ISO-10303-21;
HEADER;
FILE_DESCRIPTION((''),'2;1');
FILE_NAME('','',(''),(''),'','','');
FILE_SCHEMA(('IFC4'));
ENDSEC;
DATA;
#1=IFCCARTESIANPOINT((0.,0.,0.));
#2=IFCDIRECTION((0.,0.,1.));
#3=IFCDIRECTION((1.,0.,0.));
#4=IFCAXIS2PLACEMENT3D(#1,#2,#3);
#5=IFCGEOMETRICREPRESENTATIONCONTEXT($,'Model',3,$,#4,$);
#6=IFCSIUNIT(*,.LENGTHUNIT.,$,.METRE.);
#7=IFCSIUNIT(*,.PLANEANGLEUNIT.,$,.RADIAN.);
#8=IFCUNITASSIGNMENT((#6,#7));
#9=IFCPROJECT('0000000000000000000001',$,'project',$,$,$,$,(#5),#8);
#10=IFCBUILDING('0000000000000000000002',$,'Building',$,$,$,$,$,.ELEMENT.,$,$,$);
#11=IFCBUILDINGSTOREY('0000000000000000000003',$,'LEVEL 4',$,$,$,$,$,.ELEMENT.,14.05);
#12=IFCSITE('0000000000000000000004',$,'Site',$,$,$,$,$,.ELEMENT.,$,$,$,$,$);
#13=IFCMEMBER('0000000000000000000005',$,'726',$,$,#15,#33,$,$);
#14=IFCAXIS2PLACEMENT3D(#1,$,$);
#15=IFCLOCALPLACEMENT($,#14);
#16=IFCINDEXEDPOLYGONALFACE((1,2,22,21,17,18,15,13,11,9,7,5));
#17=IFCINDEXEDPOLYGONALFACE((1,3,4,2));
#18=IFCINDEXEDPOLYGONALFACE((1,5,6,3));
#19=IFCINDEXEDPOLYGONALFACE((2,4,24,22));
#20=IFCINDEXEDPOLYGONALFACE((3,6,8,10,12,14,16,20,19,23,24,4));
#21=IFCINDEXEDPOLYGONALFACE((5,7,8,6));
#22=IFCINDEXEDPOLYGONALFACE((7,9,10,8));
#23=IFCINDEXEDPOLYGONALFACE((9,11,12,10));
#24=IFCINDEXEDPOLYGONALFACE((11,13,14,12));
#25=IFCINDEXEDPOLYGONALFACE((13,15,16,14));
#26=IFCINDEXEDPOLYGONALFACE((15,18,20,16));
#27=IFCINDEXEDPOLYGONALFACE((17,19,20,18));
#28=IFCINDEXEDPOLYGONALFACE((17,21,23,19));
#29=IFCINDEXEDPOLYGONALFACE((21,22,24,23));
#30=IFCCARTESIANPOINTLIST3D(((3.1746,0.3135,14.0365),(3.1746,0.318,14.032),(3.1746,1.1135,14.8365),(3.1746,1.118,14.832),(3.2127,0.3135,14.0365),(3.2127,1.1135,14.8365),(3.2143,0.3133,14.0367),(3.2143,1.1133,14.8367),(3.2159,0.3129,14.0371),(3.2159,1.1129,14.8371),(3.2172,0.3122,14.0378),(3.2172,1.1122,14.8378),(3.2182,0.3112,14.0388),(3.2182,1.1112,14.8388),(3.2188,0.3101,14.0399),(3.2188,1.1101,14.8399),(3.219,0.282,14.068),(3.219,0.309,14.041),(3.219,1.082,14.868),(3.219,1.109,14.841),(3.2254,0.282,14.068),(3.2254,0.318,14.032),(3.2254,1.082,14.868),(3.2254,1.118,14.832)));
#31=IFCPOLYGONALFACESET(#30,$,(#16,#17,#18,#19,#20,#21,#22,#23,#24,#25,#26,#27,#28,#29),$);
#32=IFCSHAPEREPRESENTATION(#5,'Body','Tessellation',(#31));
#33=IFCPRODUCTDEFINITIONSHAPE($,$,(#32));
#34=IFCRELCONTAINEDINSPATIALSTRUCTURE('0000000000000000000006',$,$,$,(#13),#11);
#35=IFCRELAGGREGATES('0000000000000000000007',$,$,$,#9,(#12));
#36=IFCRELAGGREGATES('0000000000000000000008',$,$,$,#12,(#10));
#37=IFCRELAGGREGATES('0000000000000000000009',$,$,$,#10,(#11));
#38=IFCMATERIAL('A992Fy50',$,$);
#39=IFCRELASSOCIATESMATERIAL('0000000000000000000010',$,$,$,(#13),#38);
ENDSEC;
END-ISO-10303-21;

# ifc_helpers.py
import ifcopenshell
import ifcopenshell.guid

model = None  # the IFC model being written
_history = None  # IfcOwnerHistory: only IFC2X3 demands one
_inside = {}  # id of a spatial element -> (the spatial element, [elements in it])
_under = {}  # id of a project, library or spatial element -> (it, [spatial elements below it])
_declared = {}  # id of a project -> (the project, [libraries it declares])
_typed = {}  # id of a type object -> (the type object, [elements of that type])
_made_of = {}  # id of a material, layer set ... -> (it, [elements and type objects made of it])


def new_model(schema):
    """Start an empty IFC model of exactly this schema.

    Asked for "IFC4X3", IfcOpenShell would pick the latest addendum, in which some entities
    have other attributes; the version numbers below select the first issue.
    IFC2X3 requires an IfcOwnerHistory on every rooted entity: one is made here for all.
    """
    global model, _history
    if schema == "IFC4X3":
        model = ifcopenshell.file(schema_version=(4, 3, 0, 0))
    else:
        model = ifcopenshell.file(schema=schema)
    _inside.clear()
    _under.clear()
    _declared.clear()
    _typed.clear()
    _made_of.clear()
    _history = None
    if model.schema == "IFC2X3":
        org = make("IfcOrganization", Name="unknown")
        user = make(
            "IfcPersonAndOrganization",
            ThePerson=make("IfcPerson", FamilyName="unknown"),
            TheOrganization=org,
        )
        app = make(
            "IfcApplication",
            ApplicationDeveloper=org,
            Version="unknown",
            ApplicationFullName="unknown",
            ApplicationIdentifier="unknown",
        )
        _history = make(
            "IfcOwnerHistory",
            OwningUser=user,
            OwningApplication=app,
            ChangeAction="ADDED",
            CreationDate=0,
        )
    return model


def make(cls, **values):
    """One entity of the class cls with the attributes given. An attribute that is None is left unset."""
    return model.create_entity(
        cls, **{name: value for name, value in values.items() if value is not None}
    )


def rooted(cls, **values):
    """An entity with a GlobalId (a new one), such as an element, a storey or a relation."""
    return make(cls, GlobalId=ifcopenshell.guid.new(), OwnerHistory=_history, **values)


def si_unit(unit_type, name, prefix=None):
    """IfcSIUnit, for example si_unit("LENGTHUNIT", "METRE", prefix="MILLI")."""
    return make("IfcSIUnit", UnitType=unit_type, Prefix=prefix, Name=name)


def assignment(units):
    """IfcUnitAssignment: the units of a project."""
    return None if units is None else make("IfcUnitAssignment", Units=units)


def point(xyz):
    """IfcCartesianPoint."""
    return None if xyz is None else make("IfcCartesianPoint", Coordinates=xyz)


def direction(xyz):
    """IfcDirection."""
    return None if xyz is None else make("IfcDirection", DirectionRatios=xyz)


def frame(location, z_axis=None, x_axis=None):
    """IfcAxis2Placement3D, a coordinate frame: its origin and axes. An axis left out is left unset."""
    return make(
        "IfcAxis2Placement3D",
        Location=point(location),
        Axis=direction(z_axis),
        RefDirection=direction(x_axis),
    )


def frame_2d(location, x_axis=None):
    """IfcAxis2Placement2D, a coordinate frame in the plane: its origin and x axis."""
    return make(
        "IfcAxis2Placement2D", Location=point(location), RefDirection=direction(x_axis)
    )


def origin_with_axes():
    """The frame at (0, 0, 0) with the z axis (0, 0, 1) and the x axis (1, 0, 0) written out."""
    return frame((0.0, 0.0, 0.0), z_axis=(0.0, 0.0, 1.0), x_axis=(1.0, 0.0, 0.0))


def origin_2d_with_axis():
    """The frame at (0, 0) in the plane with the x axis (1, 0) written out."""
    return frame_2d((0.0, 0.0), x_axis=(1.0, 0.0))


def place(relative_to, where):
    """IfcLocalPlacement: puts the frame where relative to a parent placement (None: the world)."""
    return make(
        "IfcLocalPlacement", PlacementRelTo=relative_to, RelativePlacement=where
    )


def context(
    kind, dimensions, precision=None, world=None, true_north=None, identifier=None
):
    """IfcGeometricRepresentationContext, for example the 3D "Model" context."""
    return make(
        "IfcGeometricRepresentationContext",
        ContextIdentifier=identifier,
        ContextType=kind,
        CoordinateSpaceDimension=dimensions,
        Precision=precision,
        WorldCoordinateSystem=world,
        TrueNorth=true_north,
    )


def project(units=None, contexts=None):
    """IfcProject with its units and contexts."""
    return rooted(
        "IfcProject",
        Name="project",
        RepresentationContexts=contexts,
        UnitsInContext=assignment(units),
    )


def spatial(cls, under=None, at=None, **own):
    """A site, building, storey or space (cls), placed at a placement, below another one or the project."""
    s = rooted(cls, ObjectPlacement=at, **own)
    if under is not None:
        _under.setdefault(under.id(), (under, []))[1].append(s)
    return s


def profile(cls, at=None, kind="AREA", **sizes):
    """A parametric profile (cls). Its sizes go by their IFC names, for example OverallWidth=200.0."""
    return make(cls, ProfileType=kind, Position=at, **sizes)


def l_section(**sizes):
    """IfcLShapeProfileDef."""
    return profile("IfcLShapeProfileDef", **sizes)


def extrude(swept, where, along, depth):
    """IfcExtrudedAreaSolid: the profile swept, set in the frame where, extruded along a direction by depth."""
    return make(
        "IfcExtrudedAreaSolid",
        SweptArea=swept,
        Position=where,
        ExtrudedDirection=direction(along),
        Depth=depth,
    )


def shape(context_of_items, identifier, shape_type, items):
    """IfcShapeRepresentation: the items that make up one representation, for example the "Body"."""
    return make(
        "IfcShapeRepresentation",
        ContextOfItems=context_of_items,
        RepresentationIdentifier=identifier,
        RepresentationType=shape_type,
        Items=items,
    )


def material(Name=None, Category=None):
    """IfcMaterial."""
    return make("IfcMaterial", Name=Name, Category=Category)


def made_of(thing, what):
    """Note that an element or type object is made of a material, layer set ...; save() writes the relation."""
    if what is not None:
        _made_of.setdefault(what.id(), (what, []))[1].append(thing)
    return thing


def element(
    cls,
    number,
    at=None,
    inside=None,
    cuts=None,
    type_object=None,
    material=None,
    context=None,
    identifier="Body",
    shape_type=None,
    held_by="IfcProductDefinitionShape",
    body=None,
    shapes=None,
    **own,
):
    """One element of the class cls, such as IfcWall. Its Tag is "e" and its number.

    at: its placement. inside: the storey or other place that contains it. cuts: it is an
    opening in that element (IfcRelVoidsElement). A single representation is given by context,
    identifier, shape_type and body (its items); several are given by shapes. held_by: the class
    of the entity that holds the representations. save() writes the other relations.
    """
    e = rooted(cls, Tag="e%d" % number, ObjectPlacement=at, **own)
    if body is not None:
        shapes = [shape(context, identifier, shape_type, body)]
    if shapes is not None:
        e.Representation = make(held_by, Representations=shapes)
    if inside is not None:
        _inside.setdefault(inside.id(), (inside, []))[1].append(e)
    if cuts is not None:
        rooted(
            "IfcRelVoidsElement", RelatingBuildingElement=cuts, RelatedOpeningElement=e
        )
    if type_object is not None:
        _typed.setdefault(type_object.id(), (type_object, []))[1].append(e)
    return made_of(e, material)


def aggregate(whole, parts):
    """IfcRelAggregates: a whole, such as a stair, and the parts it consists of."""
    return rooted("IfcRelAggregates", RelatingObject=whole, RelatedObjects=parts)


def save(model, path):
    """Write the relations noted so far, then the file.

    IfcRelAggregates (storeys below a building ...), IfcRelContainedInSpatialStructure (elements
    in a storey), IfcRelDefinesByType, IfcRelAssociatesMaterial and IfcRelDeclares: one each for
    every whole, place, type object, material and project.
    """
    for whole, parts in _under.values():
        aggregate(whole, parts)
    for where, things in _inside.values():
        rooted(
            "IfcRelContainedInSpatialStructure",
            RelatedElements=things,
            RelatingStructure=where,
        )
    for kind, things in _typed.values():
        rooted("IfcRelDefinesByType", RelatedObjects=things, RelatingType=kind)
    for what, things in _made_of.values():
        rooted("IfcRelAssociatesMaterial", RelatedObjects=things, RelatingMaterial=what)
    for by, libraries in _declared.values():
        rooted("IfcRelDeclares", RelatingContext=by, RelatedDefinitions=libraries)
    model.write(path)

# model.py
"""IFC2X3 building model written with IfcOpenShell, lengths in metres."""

from ifc_helpers import new_model, si_unit, frame, origin_with_axes, origin_2d_with_axis, place, context, project, spatial, l_section, extrude, material, element, save


model = new_model("IFC2X3")

# Units and contexts
model_context = context("Model", 3, world=origin_with_axes())
ifc_project = project(units=[si_unit("LENGTHUNIT", "METRE"), si_unit("PLANEANGLEUNIT", "RADIAN")], contexts=[model_context])

# Site, building, storey
site = spatial("IfcSite", under=ifc_project, Name="Site", CompositionType="ELEMENT")
building = spatial("IfcBuilding", under=site, Name="Building", CompositionType="ELEMENT")
storey = spatial("IfcBuildingStorey", under=building, Name="LEVEL 4", CompositionType="ELEMENT", Elevation=14.05)

# Shared definitions
ifc_material = material(Name="A992Fy50")

# Member
for number, where, z_axis, x_axis, name in (
    (1, (3.2, 0.3, 14.05), (0.0, 0.707107, 0.707107), (-1.0, 0.0, 0.0), "726"),
):
    element("IfcMember", number, at=place(None, frame(where, z_axis=z_axis, x_axis=x_axis)), inside=storey, material=ifc_material, Name=name, context=model_context, shape_type="SweptSolid", body=[
        extrude(l_section(Depth=0.0508, Width=0.0508, Thickness=0.0063, FilletRadius=0.0063, at=origin_2d_with_axis()), origin_with_axes(), (0.0, 0.0, 1.0), 1.1314),
    ])

save(model, "model.ifc")
